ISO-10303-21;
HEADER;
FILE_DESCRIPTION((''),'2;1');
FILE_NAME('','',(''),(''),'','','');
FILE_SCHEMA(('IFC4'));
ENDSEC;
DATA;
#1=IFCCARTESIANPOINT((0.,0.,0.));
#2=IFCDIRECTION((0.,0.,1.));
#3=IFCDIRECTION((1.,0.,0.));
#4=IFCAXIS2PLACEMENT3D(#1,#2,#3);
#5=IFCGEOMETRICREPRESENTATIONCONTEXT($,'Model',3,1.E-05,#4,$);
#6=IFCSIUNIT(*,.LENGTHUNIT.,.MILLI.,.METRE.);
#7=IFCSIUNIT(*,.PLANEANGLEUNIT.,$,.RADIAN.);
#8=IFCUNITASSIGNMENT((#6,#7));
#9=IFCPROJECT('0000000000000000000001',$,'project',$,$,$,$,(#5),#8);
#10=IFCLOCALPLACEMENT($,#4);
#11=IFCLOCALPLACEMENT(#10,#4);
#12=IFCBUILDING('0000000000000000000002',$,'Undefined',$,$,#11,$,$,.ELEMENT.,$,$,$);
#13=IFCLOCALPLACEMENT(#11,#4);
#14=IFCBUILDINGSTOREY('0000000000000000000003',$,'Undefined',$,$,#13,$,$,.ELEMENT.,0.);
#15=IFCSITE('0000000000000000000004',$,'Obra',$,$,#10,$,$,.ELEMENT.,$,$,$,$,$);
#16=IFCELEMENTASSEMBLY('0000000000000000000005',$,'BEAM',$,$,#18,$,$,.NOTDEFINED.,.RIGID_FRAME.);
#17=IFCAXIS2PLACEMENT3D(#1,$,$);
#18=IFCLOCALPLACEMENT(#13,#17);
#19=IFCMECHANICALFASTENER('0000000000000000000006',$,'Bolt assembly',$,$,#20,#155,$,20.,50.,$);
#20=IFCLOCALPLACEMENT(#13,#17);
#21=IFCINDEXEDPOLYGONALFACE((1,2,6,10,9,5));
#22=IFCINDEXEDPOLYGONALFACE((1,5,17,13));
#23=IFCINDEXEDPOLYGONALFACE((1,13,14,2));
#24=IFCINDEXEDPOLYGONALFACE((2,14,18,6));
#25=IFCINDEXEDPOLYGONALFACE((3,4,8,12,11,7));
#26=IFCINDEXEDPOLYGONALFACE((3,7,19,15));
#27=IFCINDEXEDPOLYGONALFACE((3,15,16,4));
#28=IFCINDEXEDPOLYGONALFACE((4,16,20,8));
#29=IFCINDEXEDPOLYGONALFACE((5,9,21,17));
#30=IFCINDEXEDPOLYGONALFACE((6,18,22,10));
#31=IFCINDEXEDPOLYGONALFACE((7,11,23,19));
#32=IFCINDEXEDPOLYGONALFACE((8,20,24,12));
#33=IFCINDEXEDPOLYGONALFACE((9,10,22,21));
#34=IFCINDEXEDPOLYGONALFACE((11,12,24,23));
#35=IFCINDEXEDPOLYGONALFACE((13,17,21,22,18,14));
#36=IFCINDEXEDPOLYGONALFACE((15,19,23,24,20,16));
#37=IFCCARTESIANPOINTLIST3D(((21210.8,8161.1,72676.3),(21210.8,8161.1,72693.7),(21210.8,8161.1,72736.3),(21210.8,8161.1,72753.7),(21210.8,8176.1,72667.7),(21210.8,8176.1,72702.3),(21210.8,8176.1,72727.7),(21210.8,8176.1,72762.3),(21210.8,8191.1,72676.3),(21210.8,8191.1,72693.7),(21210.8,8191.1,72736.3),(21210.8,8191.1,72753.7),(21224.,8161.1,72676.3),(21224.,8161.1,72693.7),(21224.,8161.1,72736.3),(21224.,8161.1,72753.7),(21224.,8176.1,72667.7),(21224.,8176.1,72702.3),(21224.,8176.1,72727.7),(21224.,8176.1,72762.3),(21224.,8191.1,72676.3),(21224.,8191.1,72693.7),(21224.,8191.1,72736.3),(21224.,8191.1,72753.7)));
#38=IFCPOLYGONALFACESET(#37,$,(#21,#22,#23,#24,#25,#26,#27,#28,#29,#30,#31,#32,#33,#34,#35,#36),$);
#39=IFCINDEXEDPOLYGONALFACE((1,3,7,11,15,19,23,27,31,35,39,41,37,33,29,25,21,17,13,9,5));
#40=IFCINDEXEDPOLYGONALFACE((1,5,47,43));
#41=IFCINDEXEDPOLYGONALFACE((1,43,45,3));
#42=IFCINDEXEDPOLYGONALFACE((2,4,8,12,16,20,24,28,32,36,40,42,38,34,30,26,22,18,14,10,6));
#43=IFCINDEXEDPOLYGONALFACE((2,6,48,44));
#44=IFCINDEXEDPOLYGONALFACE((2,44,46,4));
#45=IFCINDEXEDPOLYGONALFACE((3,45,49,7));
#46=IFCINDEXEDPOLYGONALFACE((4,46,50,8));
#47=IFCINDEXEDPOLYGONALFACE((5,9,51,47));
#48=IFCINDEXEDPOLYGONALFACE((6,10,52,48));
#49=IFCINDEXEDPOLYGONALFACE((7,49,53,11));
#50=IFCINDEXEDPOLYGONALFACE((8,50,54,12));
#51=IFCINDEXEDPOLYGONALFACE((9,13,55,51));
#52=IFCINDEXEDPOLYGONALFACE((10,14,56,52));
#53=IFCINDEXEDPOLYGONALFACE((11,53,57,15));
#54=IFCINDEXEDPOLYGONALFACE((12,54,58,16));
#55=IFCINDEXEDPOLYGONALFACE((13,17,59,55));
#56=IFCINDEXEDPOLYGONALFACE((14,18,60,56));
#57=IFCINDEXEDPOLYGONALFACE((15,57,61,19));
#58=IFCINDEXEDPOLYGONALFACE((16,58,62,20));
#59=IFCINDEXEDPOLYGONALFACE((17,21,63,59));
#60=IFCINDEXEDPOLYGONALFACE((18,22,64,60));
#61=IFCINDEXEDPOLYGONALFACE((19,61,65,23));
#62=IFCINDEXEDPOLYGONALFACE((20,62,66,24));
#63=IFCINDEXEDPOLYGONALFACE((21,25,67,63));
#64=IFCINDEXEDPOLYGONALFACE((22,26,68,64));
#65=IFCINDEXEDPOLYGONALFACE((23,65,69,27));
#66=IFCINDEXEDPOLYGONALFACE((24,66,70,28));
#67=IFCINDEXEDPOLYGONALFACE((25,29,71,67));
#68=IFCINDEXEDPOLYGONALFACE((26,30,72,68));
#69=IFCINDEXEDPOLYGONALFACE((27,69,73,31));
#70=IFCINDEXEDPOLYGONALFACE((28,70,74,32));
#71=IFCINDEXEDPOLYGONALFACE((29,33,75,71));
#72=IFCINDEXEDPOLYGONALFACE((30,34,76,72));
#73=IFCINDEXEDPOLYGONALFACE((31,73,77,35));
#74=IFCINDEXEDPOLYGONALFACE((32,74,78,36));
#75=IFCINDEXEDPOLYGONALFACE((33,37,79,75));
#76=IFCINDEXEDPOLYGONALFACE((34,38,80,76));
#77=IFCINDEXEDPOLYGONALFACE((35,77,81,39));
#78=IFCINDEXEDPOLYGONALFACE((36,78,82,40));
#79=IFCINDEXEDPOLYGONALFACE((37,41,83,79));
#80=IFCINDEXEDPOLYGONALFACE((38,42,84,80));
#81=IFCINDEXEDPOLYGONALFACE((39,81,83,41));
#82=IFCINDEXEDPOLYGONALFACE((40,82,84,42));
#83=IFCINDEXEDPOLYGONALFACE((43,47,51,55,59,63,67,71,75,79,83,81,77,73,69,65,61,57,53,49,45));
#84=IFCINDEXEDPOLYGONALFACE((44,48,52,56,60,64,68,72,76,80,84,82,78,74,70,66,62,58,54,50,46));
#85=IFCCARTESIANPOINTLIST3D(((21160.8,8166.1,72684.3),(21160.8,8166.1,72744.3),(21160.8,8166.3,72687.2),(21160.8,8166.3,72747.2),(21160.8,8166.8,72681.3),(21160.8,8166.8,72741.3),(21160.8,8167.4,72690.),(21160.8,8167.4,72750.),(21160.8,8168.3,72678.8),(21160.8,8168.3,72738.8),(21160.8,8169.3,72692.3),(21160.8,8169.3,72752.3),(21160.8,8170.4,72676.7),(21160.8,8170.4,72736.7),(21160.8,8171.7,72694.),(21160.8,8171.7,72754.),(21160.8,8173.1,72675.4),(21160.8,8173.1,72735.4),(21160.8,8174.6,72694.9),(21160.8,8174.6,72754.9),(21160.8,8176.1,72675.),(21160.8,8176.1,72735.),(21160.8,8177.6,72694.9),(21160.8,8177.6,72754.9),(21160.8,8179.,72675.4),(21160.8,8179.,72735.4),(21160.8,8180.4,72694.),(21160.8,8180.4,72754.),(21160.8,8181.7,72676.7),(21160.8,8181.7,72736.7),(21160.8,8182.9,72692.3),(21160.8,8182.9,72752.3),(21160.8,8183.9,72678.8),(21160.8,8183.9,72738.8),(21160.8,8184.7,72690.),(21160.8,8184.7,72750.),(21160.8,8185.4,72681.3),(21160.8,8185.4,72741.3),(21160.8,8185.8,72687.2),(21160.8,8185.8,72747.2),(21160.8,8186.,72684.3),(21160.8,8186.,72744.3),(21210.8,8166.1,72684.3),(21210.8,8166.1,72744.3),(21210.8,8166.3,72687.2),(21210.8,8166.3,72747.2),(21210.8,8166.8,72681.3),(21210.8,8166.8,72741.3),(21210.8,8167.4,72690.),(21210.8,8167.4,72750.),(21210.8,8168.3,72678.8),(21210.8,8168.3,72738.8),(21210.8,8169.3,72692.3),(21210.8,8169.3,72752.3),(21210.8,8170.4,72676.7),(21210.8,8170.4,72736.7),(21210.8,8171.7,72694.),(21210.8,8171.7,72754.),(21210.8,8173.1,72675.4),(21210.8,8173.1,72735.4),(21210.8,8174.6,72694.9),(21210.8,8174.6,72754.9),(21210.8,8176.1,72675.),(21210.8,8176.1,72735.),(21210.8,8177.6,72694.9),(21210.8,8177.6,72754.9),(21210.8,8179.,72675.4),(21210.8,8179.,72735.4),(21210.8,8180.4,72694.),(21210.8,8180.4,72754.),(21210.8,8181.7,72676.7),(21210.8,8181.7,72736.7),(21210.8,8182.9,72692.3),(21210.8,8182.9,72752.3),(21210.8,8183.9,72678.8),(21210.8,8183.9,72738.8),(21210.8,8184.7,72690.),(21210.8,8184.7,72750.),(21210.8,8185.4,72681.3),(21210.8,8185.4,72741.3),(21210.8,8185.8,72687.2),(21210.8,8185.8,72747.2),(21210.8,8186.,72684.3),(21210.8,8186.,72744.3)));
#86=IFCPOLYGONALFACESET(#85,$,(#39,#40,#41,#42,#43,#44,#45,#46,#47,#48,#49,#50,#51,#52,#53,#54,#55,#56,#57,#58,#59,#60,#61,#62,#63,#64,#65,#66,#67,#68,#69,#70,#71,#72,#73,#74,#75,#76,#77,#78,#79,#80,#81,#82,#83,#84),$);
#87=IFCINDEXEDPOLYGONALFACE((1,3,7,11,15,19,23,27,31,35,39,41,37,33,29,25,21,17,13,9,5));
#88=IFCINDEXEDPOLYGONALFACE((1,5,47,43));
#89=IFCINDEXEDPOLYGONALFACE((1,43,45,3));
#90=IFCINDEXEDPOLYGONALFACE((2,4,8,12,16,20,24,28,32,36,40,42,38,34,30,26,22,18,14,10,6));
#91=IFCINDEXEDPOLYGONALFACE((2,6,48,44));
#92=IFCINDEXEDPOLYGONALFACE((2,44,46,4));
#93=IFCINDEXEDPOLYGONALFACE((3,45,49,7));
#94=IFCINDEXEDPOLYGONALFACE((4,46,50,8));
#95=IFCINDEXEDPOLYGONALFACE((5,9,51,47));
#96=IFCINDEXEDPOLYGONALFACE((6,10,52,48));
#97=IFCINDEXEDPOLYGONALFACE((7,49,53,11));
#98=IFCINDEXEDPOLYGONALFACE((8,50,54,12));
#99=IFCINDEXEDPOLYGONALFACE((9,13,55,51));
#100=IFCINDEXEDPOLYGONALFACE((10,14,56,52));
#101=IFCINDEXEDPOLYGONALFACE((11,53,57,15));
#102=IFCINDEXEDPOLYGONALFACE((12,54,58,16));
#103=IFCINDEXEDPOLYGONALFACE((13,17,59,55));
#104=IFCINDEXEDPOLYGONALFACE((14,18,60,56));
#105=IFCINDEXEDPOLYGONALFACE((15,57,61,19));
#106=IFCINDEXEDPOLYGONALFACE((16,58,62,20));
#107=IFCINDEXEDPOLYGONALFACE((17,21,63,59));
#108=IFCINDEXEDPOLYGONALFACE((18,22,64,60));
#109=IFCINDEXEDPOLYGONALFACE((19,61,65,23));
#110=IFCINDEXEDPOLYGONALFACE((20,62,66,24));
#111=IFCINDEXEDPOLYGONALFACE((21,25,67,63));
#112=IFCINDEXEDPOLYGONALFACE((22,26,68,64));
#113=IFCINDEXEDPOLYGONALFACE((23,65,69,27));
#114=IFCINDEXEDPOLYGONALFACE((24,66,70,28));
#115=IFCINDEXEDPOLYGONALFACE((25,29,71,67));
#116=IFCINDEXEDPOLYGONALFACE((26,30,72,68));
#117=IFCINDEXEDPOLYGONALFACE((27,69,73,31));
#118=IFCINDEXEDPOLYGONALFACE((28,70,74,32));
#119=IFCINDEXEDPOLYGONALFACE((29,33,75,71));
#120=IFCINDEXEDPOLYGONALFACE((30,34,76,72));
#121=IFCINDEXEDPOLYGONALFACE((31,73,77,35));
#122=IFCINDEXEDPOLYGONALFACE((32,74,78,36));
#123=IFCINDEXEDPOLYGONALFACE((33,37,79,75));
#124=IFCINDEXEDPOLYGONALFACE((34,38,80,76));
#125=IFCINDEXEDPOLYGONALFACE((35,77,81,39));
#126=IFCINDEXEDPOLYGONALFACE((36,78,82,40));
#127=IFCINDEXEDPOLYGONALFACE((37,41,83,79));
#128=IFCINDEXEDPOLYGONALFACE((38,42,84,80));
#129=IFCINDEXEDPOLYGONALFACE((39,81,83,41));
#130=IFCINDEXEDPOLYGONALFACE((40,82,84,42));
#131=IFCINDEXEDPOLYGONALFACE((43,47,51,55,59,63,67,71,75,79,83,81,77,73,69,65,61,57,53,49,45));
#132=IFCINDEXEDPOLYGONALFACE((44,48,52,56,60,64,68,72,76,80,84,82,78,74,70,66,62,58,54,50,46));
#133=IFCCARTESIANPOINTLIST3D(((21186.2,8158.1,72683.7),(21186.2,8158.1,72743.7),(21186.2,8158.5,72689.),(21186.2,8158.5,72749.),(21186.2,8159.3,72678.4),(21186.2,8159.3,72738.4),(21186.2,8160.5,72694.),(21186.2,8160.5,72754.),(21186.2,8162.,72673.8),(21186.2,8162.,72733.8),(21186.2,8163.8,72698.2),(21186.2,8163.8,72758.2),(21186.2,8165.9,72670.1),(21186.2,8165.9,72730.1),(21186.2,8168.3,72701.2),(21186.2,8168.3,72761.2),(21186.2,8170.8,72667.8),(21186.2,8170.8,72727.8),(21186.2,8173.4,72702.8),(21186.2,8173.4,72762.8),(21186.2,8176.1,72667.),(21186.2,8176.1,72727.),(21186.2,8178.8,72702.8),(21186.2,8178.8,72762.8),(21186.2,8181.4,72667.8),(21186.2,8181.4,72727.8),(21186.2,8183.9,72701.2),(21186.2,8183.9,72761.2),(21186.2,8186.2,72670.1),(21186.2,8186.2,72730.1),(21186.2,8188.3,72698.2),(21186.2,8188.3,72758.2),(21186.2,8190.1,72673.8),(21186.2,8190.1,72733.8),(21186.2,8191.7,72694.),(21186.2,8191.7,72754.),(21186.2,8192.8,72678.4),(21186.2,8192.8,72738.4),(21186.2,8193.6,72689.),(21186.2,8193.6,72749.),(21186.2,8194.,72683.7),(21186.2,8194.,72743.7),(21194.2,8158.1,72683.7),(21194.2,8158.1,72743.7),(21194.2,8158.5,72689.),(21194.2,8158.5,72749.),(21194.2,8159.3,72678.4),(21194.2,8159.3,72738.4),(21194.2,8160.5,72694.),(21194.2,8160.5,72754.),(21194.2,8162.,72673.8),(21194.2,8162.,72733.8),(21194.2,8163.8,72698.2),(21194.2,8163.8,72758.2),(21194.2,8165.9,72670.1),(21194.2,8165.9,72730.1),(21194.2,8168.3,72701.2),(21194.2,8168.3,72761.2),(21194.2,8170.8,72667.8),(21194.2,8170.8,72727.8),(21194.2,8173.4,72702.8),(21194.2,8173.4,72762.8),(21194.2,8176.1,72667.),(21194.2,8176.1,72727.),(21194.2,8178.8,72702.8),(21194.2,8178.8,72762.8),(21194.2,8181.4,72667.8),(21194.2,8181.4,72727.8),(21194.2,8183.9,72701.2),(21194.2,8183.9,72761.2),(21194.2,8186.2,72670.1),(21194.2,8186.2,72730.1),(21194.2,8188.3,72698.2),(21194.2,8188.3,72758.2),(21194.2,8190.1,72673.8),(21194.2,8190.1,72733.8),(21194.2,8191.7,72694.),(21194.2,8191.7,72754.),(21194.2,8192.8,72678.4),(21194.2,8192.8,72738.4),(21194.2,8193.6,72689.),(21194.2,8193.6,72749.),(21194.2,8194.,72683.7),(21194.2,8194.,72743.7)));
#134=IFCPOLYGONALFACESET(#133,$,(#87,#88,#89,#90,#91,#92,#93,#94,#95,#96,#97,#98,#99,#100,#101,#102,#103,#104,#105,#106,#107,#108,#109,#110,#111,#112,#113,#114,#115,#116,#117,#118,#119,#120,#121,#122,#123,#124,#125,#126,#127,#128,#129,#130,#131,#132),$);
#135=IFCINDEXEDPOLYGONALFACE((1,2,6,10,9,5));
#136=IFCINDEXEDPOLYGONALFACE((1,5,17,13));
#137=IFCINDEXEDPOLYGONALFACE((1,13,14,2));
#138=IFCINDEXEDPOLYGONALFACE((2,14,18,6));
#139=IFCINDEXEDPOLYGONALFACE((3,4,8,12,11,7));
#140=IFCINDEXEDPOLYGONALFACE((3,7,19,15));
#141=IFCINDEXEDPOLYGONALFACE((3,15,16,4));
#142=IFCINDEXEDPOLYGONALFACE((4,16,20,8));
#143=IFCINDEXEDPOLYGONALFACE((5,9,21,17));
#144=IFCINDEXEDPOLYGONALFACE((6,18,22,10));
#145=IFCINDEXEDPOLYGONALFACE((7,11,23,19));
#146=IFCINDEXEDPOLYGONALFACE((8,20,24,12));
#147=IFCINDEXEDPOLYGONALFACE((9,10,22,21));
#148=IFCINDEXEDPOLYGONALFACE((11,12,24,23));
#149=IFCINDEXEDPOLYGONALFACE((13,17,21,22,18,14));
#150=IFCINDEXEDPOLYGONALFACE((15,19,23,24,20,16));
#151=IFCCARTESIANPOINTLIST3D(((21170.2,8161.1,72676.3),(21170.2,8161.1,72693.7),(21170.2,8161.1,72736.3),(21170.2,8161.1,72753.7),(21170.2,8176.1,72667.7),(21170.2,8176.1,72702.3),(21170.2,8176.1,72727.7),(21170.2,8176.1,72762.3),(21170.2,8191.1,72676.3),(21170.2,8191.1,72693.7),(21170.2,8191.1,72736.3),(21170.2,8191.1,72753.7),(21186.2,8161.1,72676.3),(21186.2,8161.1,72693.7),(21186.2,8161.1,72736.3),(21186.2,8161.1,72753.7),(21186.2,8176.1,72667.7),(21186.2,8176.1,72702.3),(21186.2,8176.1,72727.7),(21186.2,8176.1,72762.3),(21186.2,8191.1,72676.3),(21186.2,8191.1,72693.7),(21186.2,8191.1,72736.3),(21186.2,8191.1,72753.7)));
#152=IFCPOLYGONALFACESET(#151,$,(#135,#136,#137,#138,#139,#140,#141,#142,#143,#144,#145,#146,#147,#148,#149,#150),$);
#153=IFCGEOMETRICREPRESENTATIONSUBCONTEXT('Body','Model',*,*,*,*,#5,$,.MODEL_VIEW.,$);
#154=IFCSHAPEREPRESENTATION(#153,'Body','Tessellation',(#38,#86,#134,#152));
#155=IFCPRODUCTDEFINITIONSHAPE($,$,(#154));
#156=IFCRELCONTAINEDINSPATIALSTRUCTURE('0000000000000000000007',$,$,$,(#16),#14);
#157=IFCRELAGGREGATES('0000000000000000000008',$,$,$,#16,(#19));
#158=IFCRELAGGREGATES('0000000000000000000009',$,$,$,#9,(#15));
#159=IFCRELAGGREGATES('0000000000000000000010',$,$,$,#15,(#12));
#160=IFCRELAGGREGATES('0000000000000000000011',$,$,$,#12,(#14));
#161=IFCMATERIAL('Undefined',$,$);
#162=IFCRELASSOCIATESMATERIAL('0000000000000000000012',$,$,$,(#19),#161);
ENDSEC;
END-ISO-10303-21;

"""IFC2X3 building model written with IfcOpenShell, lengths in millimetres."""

from ifc_helpers import new_model, si_unit, frame, origin_with_axes, origin_2d_with_axis, place, context, subcontext, project, spatial, polyline, circle, outline, extrude, source, transform, mapped, material, element, aggregate, save


model = new_model("IFC2X3")

# Units and contexts
model_context = context("Model", 3, precision=1e-05, world=origin_with_axes())
body_context = subcontext(model_context, "Body", "Model", "MODEL_VIEW")
ifc_project = project(units=[si_unit("LENGTHUNIT", "METRE", prefix="MILLI"), si_unit("PLANEANGLEUNIT", "RADIAN")], contexts=[model_context])

# Site, building, storey
site_placement = place(None, origin_with_axes())
site = spatial("IfcSite", under=ifc_project, at=site_placement, Name="Obra", CompositionType="ELEMENT")
building_placement = place(site_placement, origin_with_axes())
building = spatial("IfcBuilding", under=site, at=building_placement, Name="Undefined", CompositionType="ELEMENT")
storey_placement = place(building_placement, origin_with_axes())
storey = spatial("IfcBuildingStorey", under=building, at=storey_placement, Name="Undefined", CompositionType="ELEMENT", Elevation=0.0)

# Shared definitions
ifc_material = material(Name="Undefined")

# Element assembly, mechanical fastener
shared_shape_1 = source(origin_with_axes(), body_context, "Body", "SweptSolid", [
    extrude(outline(polyline([(17.3, 0.0), (8.7, 15.0), (-8.7, 15.0), (-17.3, 0.0), (-8.7, -15.0), (8.7, -15.0), (17.3, 0.0)])), frame((0.0, -26.5, 0.0), z_axis=(0.0, 1.0, 0.0), x_axis=(1.0, 0.0, 0.0)), (0.0, 0.0, 1.0), 13.2),
    extrude(circle(Radius=10.0, at=origin_2d_with_axis()), frame((0.0, -13.3, 0.0), z_axis=(0.0, 1.0, 0.0), x_axis=(1.0, 0.0, 0.0)), (0.0, 0.0, 1.0), 50.0),
    extrude(circle(Radius=18.0, at=origin_2d_with_axis()), frame((0.0, 3.3, 0.0), z_axis=(0.0, 1.0, 0.0), x_axis=(1.0, 0.0, 0.0)), (0.0, 0.0, 1.0), 8.0),
    extrude(outline(polyline([(17.3, 0.0), (8.7, 15.0), (-8.7, 15.0), (-17.3, 0.0), (-8.7, -15.0), (8.7, -15.0), (17.3, 0.0)])), frame((0.0, 11.3, 0.0), z_axis=(0.0, 1.0, 0.0), x_axis=(1.0, 0.0, 0.0)), (0.0, 0.0, 1.0), 16.0),
])
assembly_1_placement = place(storey_placement, origin_with_axes())
assembly_1 = element("IfcElementAssembly", 1, at=assembly_1_placement, inside=storey, Name="BEAM", AssemblyPlace="NOTDEFINED", PredefinedType="RIGID_FRAME")
mechanical_fastener_1_placement = place(assembly_1_placement, frame((21197.5, 8136.1, 72850.0), z_axis=(0.0, 1.0, 0.0), x_axis=(0.0, 0.0, -1.0)))
mechanical_fastener_1 = element("IfcMechanicalFastener", 2, at=mechanical_fastener_1_placement, material=ifc_material, Name="Bolt assembly", NominalDiameter=20.0, NominalLength=50.0, context=body_context, shape_type="MappedRepresentation", body=[
    mapped(shared_shape_1, transform((105.0, 0.0, 40.0))),
    mapped(shared_shape_1, transform((165.0, 0.0, 40.0))),
])
aggregate(assembly_1, [mechanical_fastener_1])

save(model, "model.ifc")
